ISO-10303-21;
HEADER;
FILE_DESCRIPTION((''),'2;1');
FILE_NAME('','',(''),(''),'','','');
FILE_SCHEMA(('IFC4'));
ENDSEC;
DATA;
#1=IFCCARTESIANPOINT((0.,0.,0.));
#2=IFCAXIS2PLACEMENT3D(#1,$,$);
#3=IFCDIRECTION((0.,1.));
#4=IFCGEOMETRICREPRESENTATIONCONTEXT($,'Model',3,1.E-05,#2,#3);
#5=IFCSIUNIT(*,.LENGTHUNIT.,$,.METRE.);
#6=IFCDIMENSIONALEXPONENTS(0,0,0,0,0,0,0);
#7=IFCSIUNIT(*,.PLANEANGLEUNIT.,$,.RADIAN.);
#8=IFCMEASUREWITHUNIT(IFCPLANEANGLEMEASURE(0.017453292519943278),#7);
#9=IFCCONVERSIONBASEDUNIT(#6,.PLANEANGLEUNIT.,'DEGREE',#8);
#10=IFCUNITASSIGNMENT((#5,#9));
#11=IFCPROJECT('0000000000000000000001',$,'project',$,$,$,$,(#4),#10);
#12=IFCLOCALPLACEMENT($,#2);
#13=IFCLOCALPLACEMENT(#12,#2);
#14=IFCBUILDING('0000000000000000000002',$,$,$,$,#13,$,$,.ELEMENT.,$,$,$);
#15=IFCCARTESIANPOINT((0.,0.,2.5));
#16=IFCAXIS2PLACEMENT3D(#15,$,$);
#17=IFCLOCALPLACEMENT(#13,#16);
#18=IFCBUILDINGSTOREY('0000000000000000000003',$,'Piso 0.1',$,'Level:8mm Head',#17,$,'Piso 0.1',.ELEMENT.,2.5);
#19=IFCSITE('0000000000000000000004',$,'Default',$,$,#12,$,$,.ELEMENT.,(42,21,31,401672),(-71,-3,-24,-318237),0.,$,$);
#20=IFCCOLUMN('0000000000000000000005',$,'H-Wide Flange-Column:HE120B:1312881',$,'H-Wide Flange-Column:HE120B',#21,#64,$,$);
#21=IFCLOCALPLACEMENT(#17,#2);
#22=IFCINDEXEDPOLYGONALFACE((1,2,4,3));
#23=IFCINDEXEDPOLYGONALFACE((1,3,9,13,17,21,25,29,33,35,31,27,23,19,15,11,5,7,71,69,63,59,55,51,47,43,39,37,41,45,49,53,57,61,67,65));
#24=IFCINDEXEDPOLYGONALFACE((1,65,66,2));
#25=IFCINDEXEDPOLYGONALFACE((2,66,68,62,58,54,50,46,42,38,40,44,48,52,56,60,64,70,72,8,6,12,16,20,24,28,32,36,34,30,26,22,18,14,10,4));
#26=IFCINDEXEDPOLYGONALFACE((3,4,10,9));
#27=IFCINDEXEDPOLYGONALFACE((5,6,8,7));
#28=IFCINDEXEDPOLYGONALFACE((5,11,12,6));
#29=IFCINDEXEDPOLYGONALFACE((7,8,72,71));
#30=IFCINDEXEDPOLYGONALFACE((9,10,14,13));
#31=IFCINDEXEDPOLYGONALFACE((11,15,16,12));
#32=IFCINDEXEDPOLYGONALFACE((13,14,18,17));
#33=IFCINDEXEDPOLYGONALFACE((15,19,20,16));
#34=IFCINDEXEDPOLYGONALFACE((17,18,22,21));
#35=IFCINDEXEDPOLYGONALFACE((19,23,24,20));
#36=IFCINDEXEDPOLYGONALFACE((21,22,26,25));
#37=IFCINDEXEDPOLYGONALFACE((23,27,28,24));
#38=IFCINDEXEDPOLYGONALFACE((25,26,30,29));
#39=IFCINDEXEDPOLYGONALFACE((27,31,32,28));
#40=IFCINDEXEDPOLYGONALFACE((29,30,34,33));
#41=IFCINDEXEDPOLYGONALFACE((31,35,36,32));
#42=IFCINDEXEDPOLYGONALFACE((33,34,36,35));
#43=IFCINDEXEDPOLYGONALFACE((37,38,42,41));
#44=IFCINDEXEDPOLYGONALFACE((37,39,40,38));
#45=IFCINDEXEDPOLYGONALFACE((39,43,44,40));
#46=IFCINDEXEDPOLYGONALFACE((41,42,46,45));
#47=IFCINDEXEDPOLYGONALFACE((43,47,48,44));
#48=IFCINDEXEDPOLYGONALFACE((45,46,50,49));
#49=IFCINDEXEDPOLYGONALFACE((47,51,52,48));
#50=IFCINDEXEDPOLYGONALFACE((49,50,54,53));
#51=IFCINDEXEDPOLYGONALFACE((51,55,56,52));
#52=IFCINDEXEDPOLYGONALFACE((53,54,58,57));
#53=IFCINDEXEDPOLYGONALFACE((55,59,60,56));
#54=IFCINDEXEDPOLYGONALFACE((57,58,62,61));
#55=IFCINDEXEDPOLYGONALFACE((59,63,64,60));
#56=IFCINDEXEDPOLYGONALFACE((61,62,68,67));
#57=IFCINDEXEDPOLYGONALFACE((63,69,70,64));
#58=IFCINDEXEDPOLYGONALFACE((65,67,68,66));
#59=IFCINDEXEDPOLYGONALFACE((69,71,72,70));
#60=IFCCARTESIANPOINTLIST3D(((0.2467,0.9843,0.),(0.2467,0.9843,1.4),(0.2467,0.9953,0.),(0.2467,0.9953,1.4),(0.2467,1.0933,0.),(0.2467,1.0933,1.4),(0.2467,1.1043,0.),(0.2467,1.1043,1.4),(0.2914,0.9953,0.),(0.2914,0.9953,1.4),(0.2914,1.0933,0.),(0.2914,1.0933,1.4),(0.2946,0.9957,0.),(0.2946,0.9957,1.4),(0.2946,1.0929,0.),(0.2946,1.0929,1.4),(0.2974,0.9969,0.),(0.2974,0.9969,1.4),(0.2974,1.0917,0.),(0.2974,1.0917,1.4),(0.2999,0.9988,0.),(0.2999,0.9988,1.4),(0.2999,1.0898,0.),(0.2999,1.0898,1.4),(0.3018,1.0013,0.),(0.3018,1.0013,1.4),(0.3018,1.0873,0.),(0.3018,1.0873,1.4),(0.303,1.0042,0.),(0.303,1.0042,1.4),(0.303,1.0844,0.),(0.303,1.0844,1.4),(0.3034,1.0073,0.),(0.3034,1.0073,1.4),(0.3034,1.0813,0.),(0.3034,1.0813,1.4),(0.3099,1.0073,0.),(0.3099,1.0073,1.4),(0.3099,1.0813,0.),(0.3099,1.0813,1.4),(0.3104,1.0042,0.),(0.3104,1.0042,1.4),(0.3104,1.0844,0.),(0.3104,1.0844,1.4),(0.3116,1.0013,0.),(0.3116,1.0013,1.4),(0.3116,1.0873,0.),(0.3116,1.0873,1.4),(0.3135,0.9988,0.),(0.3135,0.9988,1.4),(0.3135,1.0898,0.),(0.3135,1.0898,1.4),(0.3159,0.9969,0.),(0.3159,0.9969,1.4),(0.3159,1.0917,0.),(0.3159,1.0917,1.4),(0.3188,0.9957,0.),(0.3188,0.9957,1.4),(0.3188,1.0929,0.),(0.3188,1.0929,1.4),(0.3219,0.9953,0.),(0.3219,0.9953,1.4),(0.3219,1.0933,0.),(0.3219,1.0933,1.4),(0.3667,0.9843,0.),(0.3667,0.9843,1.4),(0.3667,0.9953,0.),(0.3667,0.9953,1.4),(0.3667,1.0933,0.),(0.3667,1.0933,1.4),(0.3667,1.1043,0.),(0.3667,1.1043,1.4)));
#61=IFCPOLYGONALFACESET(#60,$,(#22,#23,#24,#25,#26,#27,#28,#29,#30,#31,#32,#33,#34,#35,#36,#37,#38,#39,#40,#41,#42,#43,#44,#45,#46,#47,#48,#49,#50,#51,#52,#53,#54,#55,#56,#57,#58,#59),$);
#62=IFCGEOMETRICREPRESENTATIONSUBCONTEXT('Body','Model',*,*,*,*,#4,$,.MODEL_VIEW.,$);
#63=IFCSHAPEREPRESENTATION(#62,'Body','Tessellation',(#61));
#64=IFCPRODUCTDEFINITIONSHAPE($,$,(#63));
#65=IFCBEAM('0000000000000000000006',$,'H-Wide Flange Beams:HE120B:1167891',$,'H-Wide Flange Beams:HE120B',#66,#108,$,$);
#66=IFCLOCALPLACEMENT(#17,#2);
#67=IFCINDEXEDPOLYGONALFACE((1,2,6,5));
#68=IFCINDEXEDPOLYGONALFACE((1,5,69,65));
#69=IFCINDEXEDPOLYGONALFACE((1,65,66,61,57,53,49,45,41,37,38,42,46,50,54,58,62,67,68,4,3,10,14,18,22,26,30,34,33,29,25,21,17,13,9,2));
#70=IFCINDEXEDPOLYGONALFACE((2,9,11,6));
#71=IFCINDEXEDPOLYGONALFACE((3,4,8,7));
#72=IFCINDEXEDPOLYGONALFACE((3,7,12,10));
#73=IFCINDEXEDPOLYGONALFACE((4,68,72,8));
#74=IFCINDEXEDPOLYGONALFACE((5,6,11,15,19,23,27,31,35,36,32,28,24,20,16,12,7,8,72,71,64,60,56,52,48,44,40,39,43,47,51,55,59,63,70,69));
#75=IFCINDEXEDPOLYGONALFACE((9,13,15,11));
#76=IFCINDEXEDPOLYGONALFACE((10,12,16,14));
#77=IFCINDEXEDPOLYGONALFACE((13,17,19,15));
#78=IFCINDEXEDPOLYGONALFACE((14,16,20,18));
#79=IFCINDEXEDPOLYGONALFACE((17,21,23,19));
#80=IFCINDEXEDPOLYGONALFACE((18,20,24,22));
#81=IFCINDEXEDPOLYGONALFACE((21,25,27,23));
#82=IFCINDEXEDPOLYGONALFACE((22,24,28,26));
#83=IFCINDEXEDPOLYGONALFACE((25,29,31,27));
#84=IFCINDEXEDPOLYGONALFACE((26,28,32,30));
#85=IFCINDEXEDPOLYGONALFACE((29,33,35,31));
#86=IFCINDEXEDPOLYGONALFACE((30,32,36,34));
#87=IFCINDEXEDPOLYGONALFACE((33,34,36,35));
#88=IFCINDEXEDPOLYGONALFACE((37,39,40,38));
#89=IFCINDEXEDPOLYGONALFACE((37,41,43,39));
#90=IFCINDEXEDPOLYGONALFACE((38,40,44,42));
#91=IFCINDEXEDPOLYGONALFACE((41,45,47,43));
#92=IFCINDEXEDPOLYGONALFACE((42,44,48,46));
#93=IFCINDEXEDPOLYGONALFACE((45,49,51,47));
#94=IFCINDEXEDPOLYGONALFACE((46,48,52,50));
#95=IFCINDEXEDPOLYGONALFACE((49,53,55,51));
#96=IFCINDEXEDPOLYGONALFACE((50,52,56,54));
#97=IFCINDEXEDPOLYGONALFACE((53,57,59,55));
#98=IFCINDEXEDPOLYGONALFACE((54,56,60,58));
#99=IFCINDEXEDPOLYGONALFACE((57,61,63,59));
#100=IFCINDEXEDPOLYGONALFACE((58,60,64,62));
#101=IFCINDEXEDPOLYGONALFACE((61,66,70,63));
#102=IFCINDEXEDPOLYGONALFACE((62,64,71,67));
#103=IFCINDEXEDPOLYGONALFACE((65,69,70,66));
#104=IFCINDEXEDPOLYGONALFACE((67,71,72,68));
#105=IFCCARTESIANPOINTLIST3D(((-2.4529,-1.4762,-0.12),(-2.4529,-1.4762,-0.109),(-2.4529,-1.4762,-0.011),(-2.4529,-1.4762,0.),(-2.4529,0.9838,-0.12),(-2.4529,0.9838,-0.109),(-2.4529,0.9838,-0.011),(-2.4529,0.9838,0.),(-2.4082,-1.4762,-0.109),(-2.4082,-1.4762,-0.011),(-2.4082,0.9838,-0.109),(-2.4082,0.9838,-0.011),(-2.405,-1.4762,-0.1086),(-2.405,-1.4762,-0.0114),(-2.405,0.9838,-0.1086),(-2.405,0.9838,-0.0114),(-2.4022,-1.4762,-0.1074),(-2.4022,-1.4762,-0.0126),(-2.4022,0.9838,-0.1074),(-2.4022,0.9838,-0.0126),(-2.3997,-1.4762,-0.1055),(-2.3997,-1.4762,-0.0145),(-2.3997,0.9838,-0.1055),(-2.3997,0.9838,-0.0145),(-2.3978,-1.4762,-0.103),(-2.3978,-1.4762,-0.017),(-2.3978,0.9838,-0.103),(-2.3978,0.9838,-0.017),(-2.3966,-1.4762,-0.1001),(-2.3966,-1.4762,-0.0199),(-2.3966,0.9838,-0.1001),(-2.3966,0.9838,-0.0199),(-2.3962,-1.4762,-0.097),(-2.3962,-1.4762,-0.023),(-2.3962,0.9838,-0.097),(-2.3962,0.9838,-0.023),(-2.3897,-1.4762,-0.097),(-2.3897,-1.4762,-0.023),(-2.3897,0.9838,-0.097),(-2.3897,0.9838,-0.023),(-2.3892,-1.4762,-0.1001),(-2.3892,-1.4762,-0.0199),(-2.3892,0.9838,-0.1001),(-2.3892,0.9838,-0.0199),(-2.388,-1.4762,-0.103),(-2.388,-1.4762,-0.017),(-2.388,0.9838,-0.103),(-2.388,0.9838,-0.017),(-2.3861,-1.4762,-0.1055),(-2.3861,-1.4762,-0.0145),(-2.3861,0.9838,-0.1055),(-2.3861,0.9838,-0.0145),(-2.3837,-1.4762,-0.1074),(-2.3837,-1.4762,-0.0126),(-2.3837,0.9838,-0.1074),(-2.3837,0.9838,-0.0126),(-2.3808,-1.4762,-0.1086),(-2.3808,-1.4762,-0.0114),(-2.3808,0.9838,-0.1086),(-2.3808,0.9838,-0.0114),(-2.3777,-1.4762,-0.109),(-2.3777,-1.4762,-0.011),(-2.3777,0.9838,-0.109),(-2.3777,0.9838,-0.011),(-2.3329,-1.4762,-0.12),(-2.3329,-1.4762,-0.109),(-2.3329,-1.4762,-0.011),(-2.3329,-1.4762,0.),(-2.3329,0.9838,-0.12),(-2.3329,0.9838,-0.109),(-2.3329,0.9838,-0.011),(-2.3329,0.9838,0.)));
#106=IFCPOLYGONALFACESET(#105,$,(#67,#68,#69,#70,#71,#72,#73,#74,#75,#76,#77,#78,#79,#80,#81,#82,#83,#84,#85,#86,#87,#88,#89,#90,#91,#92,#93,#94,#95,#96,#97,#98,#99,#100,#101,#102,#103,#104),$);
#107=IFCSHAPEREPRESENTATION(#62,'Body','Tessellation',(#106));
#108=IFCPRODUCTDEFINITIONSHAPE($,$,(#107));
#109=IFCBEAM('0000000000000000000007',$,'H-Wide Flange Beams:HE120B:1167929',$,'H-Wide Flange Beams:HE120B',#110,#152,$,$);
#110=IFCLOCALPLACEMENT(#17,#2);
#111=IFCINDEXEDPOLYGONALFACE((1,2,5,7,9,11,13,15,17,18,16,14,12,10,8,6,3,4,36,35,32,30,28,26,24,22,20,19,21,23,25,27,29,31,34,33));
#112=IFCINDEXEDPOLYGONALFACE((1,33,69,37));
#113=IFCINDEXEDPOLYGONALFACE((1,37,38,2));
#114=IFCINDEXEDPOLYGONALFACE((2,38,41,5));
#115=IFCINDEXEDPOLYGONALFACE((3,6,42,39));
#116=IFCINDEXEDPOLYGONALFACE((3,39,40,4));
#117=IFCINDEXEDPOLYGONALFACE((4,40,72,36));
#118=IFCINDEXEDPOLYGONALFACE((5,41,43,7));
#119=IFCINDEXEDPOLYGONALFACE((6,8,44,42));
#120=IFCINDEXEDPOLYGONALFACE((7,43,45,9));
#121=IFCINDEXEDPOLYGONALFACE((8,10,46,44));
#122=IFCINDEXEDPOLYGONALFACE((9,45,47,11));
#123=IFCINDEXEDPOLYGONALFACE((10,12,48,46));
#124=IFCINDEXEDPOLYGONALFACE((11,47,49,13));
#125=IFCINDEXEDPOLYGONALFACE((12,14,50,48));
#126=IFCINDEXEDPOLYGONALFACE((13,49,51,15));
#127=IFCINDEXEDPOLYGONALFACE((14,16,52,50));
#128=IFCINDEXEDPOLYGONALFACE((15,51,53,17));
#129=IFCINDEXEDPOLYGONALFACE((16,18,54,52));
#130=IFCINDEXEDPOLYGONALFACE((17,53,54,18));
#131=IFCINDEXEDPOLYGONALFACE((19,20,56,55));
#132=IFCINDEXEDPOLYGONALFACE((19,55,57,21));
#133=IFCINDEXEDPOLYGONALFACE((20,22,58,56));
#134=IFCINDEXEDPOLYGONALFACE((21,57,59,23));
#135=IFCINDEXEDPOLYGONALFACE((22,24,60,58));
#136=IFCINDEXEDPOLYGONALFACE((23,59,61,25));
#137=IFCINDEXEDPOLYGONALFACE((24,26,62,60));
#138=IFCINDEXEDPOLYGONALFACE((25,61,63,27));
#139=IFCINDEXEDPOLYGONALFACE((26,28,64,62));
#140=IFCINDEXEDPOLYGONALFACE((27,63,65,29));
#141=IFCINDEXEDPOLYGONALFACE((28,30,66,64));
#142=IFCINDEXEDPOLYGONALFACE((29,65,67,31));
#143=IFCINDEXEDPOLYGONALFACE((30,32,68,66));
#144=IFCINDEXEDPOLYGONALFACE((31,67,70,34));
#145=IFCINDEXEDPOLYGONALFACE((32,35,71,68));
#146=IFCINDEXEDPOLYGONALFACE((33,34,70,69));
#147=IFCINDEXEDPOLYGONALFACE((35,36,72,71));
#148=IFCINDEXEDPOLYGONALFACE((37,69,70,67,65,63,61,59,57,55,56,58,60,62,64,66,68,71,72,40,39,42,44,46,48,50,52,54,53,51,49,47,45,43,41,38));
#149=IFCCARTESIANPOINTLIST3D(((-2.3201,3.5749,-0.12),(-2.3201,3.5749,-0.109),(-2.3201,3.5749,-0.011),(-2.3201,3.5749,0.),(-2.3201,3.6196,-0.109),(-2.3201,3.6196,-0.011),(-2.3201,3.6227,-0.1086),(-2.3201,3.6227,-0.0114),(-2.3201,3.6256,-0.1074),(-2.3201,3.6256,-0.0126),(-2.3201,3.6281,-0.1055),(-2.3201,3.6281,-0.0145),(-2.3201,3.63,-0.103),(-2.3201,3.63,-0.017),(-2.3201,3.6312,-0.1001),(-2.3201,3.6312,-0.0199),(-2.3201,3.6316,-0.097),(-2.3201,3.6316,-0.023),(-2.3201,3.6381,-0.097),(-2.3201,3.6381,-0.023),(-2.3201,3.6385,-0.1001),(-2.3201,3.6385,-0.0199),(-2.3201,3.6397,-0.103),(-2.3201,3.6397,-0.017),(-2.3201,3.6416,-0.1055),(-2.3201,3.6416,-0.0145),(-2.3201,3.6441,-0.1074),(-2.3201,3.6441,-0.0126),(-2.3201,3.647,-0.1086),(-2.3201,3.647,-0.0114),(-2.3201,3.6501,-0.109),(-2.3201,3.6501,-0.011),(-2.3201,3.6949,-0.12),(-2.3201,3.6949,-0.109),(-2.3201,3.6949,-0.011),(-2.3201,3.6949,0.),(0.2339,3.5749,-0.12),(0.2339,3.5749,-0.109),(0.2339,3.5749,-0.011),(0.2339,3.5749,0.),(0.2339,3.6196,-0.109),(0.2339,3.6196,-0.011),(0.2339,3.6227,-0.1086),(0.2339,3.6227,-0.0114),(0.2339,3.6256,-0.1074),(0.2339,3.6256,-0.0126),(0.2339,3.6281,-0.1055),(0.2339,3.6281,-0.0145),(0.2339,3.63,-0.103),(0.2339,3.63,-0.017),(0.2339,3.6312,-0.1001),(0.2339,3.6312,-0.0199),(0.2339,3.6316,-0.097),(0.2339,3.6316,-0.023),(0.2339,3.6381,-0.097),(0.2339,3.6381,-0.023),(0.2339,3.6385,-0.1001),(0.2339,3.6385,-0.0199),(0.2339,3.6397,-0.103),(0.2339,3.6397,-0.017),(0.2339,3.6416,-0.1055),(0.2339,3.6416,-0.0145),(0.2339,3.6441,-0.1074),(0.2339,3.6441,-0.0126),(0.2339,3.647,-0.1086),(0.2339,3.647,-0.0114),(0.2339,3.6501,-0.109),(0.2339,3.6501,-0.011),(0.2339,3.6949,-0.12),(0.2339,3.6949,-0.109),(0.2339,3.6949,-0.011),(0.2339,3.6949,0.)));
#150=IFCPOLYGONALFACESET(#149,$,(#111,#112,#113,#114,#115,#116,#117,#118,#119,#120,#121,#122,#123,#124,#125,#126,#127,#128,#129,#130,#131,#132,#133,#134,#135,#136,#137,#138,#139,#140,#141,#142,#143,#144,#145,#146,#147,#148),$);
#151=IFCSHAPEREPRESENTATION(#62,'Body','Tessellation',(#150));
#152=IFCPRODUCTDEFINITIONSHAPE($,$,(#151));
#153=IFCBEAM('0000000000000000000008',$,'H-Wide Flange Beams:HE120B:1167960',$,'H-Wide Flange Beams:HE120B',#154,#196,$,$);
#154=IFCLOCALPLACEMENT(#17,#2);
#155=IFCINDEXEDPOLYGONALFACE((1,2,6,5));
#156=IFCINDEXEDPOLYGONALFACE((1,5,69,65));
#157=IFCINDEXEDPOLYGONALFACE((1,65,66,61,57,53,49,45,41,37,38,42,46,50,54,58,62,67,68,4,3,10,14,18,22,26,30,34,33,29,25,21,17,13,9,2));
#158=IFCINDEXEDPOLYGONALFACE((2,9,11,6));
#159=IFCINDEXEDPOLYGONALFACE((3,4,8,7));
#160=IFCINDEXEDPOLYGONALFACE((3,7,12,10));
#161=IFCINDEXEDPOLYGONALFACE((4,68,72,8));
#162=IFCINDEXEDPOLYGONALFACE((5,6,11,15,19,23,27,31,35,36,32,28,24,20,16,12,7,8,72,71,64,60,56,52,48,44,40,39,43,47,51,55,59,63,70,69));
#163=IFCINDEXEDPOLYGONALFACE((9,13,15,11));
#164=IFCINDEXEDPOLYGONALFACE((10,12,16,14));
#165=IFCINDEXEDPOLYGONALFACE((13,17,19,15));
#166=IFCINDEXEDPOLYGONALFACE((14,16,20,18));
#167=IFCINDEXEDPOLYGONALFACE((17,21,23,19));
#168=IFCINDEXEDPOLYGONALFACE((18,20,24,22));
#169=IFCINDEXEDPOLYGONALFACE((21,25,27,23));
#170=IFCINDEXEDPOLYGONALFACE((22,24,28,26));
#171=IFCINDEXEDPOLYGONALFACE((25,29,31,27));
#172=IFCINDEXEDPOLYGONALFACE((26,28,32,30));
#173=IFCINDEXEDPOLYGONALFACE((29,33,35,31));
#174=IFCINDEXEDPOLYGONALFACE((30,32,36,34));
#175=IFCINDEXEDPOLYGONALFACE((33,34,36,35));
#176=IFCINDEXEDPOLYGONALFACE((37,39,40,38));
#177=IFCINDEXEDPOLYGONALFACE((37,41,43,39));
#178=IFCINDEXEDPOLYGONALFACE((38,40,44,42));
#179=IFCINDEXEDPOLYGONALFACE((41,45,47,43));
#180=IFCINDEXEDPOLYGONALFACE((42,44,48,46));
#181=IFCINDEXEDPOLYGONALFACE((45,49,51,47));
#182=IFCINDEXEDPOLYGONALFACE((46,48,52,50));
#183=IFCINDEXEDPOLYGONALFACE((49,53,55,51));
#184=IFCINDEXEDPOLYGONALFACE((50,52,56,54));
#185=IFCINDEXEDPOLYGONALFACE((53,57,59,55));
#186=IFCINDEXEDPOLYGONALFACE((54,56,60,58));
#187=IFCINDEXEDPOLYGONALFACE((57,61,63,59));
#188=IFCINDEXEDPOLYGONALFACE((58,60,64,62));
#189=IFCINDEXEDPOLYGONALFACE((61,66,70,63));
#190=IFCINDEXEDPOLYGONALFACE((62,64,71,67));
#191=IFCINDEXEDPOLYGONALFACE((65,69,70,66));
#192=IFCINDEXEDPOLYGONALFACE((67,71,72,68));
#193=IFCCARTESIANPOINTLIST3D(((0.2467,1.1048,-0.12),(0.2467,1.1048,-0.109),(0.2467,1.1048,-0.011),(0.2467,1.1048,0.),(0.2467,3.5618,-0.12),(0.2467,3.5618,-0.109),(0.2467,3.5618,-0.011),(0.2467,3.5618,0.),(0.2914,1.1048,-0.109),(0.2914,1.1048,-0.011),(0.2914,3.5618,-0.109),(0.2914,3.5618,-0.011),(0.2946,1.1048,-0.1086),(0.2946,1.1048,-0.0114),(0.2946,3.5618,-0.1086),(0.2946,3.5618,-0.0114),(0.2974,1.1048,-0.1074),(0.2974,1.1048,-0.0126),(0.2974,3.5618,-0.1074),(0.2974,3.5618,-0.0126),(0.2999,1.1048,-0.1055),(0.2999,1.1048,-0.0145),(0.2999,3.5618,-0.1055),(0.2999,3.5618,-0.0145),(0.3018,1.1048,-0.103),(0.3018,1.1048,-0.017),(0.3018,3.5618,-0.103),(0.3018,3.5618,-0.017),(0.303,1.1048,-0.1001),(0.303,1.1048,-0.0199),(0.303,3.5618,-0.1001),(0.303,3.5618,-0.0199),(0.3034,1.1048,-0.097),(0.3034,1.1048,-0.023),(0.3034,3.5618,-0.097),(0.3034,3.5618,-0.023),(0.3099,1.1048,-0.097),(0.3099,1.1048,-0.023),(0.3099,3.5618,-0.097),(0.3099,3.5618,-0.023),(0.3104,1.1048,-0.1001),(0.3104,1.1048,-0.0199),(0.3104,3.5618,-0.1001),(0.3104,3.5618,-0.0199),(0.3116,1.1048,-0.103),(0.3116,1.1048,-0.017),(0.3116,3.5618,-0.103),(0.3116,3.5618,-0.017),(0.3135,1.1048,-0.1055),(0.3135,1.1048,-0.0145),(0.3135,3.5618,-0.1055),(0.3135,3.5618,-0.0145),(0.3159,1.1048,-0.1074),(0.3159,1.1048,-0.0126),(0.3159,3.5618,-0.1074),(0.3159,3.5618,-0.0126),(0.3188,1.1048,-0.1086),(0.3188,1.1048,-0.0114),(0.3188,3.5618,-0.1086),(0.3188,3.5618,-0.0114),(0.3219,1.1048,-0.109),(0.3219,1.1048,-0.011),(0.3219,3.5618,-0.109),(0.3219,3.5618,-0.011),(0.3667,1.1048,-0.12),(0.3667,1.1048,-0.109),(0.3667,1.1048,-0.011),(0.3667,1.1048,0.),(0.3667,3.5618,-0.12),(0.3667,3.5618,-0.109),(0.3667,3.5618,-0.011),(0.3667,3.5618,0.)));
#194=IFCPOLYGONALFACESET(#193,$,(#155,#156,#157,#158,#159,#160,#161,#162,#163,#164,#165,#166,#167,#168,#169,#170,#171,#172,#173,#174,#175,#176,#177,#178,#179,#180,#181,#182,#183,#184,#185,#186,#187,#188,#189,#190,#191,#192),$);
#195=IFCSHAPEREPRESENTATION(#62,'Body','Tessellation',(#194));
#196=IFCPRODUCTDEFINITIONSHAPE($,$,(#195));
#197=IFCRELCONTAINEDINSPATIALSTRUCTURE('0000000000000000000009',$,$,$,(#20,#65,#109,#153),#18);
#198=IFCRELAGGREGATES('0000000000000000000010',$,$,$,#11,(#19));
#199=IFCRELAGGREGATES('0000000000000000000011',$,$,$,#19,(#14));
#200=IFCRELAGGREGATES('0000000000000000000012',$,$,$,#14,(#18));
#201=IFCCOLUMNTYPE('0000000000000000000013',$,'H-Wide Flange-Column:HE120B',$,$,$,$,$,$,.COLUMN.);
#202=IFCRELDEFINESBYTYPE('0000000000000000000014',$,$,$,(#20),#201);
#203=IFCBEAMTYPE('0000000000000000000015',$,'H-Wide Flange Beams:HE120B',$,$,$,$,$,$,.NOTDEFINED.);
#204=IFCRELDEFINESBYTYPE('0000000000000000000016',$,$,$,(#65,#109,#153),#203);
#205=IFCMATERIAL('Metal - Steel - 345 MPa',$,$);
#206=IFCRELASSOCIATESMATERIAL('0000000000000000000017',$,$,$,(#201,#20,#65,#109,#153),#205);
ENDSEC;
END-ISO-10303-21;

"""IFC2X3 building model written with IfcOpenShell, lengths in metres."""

from ifc_helpers import new_model, entity, si_unit, converted_unit, direction, frame, frame_2d, origin, place, context, subcontext, project, spatial, i_section, extrude, source, transform, mapped, material, type_object, type_shapes, element, save


model = new_model("IFC2X3")

# Units and contexts
model_context = context("Model", 3, precision=1e-05, world=origin(), true_north=direction((0.0, 1.0)))
body_context = subcontext(model_context, "Body", "Model", "MODEL_VIEW")
ifc_project = project(units=[si_unit("LENGTHUNIT", "METRE"), converted_unit("PLANEANGLEUNIT", "DEGREE", entity("IfcPlaneAngleMeasure", 0.017453292519943278), si_unit("PLANEANGLEUNIT", "RADIAN"), dimensions=[0, 0, 0, 0, 0, 0, 0])], contexts=[model_context])

# Site, building, storey
site_placement = place(None, origin())
site = spatial("IfcSite", under=ifc_project, at=site_placement, Name="Default", CompositionType="ELEMENT", RefLatitude=(42, 21, 31, 401672), RefLongitude=(-71, -3, -24, -318237), RefElevation=0.0)
building_placement = place(site_placement, origin())
building = spatial("IfcBuilding", under=site, at=building_placement, CompositionType="ELEMENT")
storey_placement = place(building_placement, frame((0.0, 0.0, 2.5)))
storey = spatial("IfcBuildingStorey", under=building, at=storey_placement, Name="Piso 0.1", ObjectType="Level:8mm Head", LongName="Piso 0.1", CompositionType="ELEMENT", Elevation=2.5)

# Column
ifc_material_1 = material(Name="Metal - Steel - 345 MPa")
column_type = type_object("IfcColumnType", Name="H-Wide Flange-Column:HE120B", PredefinedType="COLUMN", material=ifc_material_1)
shared_shape_1 = source(origin(), body_context, "Body", "SweptSolid", [
    extrude(i_section(OverallWidth=0.12, OverallDepth=0.12, WebThickness=0.0065, FlangeThickness=0.011, FilletRadius=0.012, at=frame_2d((0.0, 0.0), x_axis=(1.0, 0.0))), frame((0.0, 0.0, 2.5), z_axis=(0.0, 0.0, 1.0), x_axis=(-1.0, 0.0, 0.0)), (0.0, 0.0, 1.0), 1.4),
])
type_shapes(column_type, [shared_shape_1])
column_placement = place(storey_placement, frame((0.3067, 1.0443, -2.5)))
element("IfcColumn", 1, at=column_placement, inside=storey, type_object=column_type, material=ifc_material_1, Name="H-Wide Flange-Column:HE120B:1312881", ObjectType="H-Wide Flange-Column:HE120B", context=body_context, shape_type="MappedRepresentation", body=[
    mapped(shared_shape_1, transform((0.0, 0.0, 0.0), scale=1.0)),
])

# Beams
beam_type = type_object("IfcBeamType", Name="H-Wide Flange Beams:HE120B", PredefinedType="NOTDEFINED")
beam_1_placement = place(storey_placement, frame((-2.3929, -1.5493, 0.0), z_axis=(0.0, 0.0, 1.0), x_axis=(0.0, 1.0, 0.0)))
element("IfcBeam", 2, at=beam_1_placement, inside=storey, type_object=beam_type, material=ifc_material_1, Name="H-Wide Flange Beams:HE120B:1167891", ObjectType="H-Wide Flange Beams:HE120B", context=body_context, shape_type="SweptSolid", body=[
    extrude(i_section(OverallWidth=0.12, OverallDepth=0.12, WebThickness=0.0065, FlangeThickness=0.011, FilletRadius=0.012, at=frame_2d((0.0, 0.0), x_axis=(0.0, 1.0))), frame((0.073, 0.0, -0.06), z_axis=(1.0, 0.0, 0.0), x_axis=(0.0, 0.0, -1.0)), (0.0, 0.0, 1.0), 2.46),
])
beam_2_placement = place(storey_placement, frame((-2.3929, 3.6349, 0.0)))
element("IfcBeam", 3, at=beam_2_placement, inside=storey, type_object=beam_type, material=ifc_material_1, Name="H-Wide Flange Beams:HE120B:1167929", ObjectType="H-Wide Flange Beams:HE120B", context=body_context, shape_type="SweptSolid", body=[
    extrude(i_section(OverallWidth=0.12, OverallDepth=0.12, WebThickness=0.0065, FlangeThickness=0.011, FilletRadius=0.012, at=frame_2d((0.0, 0.0), x_axis=(0.0, 1.0))), frame((0.0728, 0.0, -0.06), z_axis=(1.0, 0.0, 0.0), x_axis=(0.0, 0.0, -1.0)), (0.0, 0.0, 1.0), 2.554),
])
beam_3_placement = place(storey_placement, frame((0.3067, 3.6349, 0.0), z_axis=(0.0, 0.0, 1.0), x_axis=(0.0, -1.0, 0.0)))
element("IfcBeam", 4, at=beam_3_placement, inside=storey, type_object=beam_type, material=ifc_material_1, Name="H-Wide Flange Beams:HE120B:1167960", ObjectType="H-Wide Flange Beams:HE120B", context=body_context, shape_type="SweptSolid", body=[
    extrude(i_section(OverallWidth=0.12, OverallDepth=0.12, WebThickness=0.0065, FlangeThickness=0.011, FilletRadius=0.012, at=frame_2d((0.0, 0.0), x_axis=(0.0, 1.0))), frame((0.073, 0.0, -0.06), z_axis=(1.0, 0.0, 0.0), x_axis=(0.0, 0.0, -1.0)), (0.0, 0.0, 1.0), 2.457),
])

save(model, "model.ifc")
